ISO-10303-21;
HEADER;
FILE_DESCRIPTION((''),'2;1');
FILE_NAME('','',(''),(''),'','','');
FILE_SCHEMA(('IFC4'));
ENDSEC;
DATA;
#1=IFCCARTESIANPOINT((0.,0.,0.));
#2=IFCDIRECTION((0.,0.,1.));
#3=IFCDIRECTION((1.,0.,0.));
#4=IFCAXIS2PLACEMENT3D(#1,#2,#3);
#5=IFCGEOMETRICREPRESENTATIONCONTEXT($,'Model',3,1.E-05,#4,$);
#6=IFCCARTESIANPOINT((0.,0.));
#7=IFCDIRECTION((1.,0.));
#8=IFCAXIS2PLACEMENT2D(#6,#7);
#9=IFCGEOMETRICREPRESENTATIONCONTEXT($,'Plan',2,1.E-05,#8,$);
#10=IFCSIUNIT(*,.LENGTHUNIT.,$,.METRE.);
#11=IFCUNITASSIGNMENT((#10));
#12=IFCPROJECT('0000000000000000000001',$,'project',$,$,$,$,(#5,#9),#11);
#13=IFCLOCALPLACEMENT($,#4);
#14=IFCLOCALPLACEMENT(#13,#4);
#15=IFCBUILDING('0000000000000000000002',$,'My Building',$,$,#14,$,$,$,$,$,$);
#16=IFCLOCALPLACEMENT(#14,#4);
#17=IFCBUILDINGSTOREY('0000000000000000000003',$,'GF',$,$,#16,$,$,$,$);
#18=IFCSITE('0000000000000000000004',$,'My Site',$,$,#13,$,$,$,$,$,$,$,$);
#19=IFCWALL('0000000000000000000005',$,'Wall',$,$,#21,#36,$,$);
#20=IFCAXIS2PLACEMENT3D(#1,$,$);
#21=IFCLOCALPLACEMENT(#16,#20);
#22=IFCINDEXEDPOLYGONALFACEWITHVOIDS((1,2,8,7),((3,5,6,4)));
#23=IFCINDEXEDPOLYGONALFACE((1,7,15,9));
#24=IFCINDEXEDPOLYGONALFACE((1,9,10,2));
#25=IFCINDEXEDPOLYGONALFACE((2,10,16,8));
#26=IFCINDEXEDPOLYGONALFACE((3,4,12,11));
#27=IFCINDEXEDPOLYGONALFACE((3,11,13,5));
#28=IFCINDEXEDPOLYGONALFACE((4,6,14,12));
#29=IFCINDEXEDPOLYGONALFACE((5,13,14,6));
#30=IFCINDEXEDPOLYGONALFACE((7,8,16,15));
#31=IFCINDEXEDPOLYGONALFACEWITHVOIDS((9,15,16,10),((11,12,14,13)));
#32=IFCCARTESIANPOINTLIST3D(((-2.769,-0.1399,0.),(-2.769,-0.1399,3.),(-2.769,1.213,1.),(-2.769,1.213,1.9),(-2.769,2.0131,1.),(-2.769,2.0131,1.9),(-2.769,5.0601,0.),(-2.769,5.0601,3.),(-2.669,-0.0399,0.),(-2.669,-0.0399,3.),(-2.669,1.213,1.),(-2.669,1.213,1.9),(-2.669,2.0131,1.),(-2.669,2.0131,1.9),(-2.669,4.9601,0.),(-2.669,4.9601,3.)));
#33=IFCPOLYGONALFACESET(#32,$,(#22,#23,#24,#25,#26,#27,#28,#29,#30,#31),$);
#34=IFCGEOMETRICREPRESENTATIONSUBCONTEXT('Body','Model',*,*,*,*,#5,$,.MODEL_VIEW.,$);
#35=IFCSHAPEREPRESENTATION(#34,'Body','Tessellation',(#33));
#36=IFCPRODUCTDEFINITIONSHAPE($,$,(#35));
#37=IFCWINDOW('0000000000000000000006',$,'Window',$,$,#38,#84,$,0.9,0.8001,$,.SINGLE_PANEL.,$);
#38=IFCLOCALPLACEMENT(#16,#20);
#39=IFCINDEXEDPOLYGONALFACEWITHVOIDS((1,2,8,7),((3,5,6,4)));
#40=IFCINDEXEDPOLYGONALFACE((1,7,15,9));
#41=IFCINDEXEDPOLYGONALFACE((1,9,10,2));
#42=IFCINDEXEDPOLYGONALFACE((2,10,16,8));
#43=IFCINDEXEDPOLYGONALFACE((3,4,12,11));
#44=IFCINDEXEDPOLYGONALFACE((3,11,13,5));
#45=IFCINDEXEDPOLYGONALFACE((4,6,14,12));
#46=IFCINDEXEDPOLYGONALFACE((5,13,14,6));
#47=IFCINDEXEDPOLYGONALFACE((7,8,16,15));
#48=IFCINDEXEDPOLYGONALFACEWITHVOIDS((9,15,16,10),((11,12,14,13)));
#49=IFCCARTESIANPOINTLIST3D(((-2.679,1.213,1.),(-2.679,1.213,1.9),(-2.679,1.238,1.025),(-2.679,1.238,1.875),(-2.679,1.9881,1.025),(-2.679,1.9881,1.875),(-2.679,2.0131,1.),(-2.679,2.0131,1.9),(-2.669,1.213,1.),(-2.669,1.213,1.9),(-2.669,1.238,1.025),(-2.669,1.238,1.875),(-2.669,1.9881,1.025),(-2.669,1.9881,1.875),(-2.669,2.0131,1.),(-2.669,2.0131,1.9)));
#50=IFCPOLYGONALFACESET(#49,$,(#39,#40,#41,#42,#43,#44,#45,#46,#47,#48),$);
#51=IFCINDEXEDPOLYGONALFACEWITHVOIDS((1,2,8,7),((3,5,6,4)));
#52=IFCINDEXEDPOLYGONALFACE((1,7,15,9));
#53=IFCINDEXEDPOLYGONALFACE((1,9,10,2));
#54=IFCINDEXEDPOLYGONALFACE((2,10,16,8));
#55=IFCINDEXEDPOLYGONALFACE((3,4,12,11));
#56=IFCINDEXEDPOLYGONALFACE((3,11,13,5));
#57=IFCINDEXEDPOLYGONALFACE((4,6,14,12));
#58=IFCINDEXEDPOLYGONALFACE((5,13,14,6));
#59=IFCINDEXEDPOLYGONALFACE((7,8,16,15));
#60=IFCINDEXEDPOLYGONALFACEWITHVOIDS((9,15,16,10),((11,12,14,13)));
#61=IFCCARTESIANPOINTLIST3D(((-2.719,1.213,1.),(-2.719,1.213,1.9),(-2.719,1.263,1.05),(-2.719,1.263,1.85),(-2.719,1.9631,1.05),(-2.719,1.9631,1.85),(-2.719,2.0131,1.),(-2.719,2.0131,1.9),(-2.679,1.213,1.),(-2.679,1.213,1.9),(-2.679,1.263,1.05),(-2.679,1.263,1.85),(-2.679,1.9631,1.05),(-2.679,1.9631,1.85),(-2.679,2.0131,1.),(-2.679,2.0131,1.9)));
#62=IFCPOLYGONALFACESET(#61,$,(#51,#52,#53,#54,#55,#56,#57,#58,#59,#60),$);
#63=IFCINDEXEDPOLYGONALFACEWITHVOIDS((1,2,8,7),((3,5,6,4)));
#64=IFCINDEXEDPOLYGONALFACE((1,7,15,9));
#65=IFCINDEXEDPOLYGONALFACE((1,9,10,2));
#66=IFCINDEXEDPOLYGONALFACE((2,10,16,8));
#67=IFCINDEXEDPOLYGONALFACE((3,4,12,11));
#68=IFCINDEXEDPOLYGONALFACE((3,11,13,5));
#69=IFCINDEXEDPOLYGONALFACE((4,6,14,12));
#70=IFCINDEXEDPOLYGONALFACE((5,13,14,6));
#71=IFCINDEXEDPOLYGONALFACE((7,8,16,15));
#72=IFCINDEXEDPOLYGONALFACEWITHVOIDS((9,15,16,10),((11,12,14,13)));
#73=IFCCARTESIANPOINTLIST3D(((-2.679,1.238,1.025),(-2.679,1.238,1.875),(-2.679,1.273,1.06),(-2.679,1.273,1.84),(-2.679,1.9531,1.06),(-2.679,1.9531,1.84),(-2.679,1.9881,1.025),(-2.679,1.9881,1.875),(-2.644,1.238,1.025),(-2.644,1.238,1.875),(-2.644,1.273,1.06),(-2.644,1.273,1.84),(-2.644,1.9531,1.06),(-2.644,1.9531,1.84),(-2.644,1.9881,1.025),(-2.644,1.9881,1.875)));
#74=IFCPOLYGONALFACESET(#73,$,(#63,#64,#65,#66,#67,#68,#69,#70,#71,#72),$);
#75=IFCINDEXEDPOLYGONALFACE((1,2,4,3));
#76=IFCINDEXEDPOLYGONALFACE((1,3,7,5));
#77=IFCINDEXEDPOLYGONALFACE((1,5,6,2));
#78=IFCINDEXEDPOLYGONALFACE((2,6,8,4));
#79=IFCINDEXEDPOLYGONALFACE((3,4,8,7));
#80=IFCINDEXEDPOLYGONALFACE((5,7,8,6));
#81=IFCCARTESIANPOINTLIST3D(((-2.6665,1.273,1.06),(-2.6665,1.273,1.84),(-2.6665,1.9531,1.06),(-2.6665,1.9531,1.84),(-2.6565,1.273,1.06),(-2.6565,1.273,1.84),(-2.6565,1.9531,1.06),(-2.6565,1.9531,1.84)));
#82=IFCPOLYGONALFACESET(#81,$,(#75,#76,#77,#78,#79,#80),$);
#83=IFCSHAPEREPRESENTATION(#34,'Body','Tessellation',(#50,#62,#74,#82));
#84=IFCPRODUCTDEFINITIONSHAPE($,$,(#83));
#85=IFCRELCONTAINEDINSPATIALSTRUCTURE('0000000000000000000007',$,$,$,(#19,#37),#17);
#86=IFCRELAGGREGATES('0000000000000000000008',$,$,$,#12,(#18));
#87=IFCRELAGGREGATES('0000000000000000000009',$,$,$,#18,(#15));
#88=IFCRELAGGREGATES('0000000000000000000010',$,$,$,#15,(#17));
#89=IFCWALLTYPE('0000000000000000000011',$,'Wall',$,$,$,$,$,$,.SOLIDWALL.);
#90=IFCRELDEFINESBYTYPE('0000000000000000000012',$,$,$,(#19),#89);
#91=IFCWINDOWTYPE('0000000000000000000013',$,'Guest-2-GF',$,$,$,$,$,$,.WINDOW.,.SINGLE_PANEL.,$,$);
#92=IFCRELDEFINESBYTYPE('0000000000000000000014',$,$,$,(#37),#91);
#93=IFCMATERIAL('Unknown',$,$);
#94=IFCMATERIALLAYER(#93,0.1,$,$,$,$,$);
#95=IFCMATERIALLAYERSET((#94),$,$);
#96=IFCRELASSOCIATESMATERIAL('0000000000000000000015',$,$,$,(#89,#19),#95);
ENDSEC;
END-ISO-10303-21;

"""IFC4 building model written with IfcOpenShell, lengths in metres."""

from ifc_helpers import new_model, entity, si_unit, frame, origin_with_axes, origin_2d_with_axis, place, context, subcontext, project, spatial, line, indexed_curve, outline, extrude, shape, source, transform, mapped, material, layer, layer_set, layer_usage, type_object, type_shapes, element, fill, save


model = new_model("IFC4")

# Units and contexts
model_context = context("Model", 3, precision=1e-05, world=origin_with_axes())
plan_context = context("Plan", 2, precision=1e-05, world=origin_2d_with_axis())
body_context_1 = subcontext(model_context, "Body", "Model", "MODEL_VIEW")
body_context_2 = subcontext(plan_context, "Body", "Plan", "PLAN_VIEW")
ifc_project = project(units=[si_unit("LENGTHUNIT", "METRE")], contexts=[model_context, plan_context])

# Site, building, storey
site_placement = place(None, origin_with_axes())
site = spatial("IfcSite", under=ifc_project, at=site_placement, Name="My Site")
building_placement = place(site_placement, origin_with_axes())
building = spatial("IfcBuilding", under=site, at=building_placement, Name="My Building")
storey_placement = place(building_placement, origin_with_axes())
storey = spatial("IfcBuildingStorey", under=building, at=storey_placement, Name="GF")

# Shared definitions
ifc_material_1 = material(Name="Unknown")

# Shared definitions
ifc_layer_1 = layer(ifc_material_1, 0.1)
ifc_layer_set_1 = layer_set([ifc_layer_1])
wall_type = type_object("IfcWallType", Name="Wall", PredefinedType="SOLIDWALL", material=ifc_layer_set_1)

# Wall, opening, window
ifc_layer_usage_1 = layer_usage(ifc_layer_set_1, "AXIS2", "POSITIVE", 0.0)
wall_1_placement = place(storey_placement, frame((-2.769, 5.0601, 0.0), z_axis=(0.0, 0.0, 1.0), x_axis=(0.0, -1.0, 0.0)))
wall_1 = element("IfcWall", 1, at=wall_1_placement, inside=storey, type_object=wall_type, material=ifc_layer_usage_1, Name="Wall", context=body_context_1, shape_type="SweptSolid", body=[
    extrude(outline(indexed_curve([(0.0, 0.0), (0.1, 0.1), (5.1, 0.1), (5.2, 0.0)], segments=[line(1, 2, 3, 4, 1)])), origin_with_axes(), (0.0, 0.0, 1.0), 3.0),
])
shared_shape_1 = source(origin_with_axes(), body_context_1, "Body", "SweptSolid", [
    extrude(outline(indexed_curve([(0.0, 0.0), (0.8001, 0.0), (0.8001, 0.9), (0.0, 0.9)], segments=[line(1, 2, 3, 4, 1)])), frame((0.0, -0.6, 0.0), z_axis=(0.0, -1.0, 0.0), x_axis=(1.0, 0.0, 0.0)), (0.0, 0.0, -1.0), 1.2),
])
opening_1_placement = place(wall_1_placement, frame((3.047, 0.0, 1.0), z_axis=(0.0, 0.0, 1.0), x_axis=(1.0, 0.0, 0.0)))
opening_1 = element("IfcOpeningElement", 2, at=opening_1_placement, cuts=wall_1, PredefinedType="OPENING", context=body_context_1, shape_type="MappedRepresentation", body=[
    mapped(shared_shape_1, transform((0.0, 0.0, 0.0), x_axis=(1.0, 0.0, 0.0), y_axis=(0.0, 1.0, 0.0), z_axis=(0.0, 0.0, 1.0), scale=1.0)),
])
window_type_1 = type_object("IfcWindowType", Name="Guest-2-GF", PartitioningType="SINGLE_PANEL", PredefinedType="WINDOW")
shared_shape_2 = source(origin_with_axes(), body_context_1, "Body", "SweptSolid", [
    extrude(outline(indexed_curve([(0.0, 0.0), (0.8001, 0.0), (0.8001, 0.9), (0.0, 0.9)], segments=[line(1, 2, 3, 4, 1)]), holes=[indexed_curve([(0.025, 0.025), (0.7751, 0.025), (0.7751, 0.875), (0.025, 0.875)], segments=[line(1, 2, 3, 4, 1)])]), frame((0.0, 0.09, 0.0), z_axis=(0.0, -1.0, 0.0), x_axis=(1.0, 0.0, 0.0)), (0.0, 0.0, -1.0), 0.01),
    extrude(outline(indexed_curve([(0.0, 0.0), (0.8001, 0.0), (0.8001, 0.9), (0.0, 0.9)], segments=[line(1, 2, 3, 4, 1)]), holes=[indexed_curve([(0.05, 0.05), (0.7501, 0.05), (0.7501, 0.85), (0.05, 0.85)], segments=[line(1, 2, 3, 4, 1)])]), frame((0.0, 0.05, 0.0), z_axis=(0.0, -1.0, 0.0), x_axis=(1.0, 0.0, 0.0)), (0.0, 0.0, -1.0), 0.04),
    extrude(outline(indexed_curve([(0.0, 0.0), (0.7501, 0.0), (0.7501, 0.85), (0.0, 0.85)], segments=[line(1, 2, 3, 4, 1)]), holes=[indexed_curve([(0.035, 0.035), (0.7151, 0.035), (0.7151, 0.815), (0.035, 0.815)], segments=[line(1, 2, 3, 4, 1)])]), frame((0.025, 0.09, 0.025), z_axis=(0.0, -1.0, 0.0), x_axis=(1.0, 0.0, 0.0)), (0.0, 0.0, -1.0), 0.035),
    extrude(outline(indexed_curve([(0.035, 0.035), (0.7151, 0.035), (0.7151, 0.815), (0.035, 0.815)], segments=[line(1, 2, 3, 4, 1)])), frame((0.025, 0.1025, 0.025), z_axis=(0.0, -1.0, 0.0), x_axis=(1.0, 0.0, 0.0)), (0.0, 0.0, -1.0), 0.01),
])
shared_shape_3 = source(origin_with_axes(), body_context_2, "Body", "Curve2D", [
    entity("IfcIndexedPolyCurve", entity("IfcCartesianPointList2D", [[0.05, 0.05], [0.7501, 0.05]])),
    entity("IfcIndexedPolyCurve", entity("IfcCartesianPointList2D", [[0.0, 0.1], [0.025, 0.1], [0.025, 0.09], [0.05, 0.09], [0.05, 0.05], [0.0, 0.05]]), [entity("IfcLineIndex", [1, 2, 3, 4, 5, 6, 1])]),
    entity("IfcIndexedPolyCurve", entity("IfcCartesianPointList2D", [[0.8001, 0.1], [0.7751, 0.1], [0.7751, 0.09], [0.7501, 0.09], [0.7501, 0.05], [0.8001, 0.05]]), [entity("IfcLineIndex", [1, 2, 3, 4, 5, 6, 1])]),
    entity("IfcIndexedPolyCurve", entity("IfcCartesianPointList2D", [[0.025, 0.09], [0.06, 0.09], [0.06, 0.125], [0.025, 0.125]]), [entity("IfcLineIndex", [1, 2, 3, 4, 1])]),
    entity("IfcIndexedPolyCurve", entity("IfcCartesianPointList2D", [[0.7751, 0.09], [0.7401, 0.09], [0.7401, 0.125], [0.7751, 0.125]]), [entity("IfcLineIndex", [1, 2, 3, 4, 1])]),
    entity("IfcIndexedPolyCurve", entity("IfcCartesianPointList2D", [[0.06, 0.09], [0.7401, 0.09]])),
    entity("IfcIndexedPolyCurve", entity("IfcCartesianPointList2D", [[0.06, 0.125], [0.7401, 0.125]])),
    entity("IfcIndexedPolyCurve", entity("IfcCartesianPointList2D", [[0.06, 0.1075], [0.7401, 0.1075]])),
])
type_shapes(window_type_1, [shared_shape_2, shared_shape_3])
window_1_placement = place(opening_1_placement, frame((0.0, 0.0, 0.0), z_axis=(0.0, 0.0, 1.0), x_axis=(1.0, 0.0, 0.0)))
window_1 = element("IfcWindow", 3, at=window_1_placement, inside=storey, type_object=window_type_1, Name="Window", OverallHeight=0.9, OverallWidth=0.8001, PartitioningType="SINGLE_PANEL", shapes=[
    shape(body_context_1, "Body", "MappedRepresentation", [mapped(shared_shape_2, transform((0.0, 0.0, 0.0), x_axis=(1.0, 0.0, 0.0), y_axis=(0.0, 1.0, 0.0), z_axis=(0.0, 0.0, 1.0), scale=1.0))]),
    shape(body_context_2, "Body", "MappedRepresentation", [mapped(shared_shape_3, transform((0.0, 0.0, 0.0), x_axis=(1.0, 0.0, 0.0), y_axis=(0.0, 1.0, 0.0), z_axis=(0.0, 0.0, 1.0), scale=1.0))]),
])
fill(opening_1, window_1)

save(model, "model.ifc")
